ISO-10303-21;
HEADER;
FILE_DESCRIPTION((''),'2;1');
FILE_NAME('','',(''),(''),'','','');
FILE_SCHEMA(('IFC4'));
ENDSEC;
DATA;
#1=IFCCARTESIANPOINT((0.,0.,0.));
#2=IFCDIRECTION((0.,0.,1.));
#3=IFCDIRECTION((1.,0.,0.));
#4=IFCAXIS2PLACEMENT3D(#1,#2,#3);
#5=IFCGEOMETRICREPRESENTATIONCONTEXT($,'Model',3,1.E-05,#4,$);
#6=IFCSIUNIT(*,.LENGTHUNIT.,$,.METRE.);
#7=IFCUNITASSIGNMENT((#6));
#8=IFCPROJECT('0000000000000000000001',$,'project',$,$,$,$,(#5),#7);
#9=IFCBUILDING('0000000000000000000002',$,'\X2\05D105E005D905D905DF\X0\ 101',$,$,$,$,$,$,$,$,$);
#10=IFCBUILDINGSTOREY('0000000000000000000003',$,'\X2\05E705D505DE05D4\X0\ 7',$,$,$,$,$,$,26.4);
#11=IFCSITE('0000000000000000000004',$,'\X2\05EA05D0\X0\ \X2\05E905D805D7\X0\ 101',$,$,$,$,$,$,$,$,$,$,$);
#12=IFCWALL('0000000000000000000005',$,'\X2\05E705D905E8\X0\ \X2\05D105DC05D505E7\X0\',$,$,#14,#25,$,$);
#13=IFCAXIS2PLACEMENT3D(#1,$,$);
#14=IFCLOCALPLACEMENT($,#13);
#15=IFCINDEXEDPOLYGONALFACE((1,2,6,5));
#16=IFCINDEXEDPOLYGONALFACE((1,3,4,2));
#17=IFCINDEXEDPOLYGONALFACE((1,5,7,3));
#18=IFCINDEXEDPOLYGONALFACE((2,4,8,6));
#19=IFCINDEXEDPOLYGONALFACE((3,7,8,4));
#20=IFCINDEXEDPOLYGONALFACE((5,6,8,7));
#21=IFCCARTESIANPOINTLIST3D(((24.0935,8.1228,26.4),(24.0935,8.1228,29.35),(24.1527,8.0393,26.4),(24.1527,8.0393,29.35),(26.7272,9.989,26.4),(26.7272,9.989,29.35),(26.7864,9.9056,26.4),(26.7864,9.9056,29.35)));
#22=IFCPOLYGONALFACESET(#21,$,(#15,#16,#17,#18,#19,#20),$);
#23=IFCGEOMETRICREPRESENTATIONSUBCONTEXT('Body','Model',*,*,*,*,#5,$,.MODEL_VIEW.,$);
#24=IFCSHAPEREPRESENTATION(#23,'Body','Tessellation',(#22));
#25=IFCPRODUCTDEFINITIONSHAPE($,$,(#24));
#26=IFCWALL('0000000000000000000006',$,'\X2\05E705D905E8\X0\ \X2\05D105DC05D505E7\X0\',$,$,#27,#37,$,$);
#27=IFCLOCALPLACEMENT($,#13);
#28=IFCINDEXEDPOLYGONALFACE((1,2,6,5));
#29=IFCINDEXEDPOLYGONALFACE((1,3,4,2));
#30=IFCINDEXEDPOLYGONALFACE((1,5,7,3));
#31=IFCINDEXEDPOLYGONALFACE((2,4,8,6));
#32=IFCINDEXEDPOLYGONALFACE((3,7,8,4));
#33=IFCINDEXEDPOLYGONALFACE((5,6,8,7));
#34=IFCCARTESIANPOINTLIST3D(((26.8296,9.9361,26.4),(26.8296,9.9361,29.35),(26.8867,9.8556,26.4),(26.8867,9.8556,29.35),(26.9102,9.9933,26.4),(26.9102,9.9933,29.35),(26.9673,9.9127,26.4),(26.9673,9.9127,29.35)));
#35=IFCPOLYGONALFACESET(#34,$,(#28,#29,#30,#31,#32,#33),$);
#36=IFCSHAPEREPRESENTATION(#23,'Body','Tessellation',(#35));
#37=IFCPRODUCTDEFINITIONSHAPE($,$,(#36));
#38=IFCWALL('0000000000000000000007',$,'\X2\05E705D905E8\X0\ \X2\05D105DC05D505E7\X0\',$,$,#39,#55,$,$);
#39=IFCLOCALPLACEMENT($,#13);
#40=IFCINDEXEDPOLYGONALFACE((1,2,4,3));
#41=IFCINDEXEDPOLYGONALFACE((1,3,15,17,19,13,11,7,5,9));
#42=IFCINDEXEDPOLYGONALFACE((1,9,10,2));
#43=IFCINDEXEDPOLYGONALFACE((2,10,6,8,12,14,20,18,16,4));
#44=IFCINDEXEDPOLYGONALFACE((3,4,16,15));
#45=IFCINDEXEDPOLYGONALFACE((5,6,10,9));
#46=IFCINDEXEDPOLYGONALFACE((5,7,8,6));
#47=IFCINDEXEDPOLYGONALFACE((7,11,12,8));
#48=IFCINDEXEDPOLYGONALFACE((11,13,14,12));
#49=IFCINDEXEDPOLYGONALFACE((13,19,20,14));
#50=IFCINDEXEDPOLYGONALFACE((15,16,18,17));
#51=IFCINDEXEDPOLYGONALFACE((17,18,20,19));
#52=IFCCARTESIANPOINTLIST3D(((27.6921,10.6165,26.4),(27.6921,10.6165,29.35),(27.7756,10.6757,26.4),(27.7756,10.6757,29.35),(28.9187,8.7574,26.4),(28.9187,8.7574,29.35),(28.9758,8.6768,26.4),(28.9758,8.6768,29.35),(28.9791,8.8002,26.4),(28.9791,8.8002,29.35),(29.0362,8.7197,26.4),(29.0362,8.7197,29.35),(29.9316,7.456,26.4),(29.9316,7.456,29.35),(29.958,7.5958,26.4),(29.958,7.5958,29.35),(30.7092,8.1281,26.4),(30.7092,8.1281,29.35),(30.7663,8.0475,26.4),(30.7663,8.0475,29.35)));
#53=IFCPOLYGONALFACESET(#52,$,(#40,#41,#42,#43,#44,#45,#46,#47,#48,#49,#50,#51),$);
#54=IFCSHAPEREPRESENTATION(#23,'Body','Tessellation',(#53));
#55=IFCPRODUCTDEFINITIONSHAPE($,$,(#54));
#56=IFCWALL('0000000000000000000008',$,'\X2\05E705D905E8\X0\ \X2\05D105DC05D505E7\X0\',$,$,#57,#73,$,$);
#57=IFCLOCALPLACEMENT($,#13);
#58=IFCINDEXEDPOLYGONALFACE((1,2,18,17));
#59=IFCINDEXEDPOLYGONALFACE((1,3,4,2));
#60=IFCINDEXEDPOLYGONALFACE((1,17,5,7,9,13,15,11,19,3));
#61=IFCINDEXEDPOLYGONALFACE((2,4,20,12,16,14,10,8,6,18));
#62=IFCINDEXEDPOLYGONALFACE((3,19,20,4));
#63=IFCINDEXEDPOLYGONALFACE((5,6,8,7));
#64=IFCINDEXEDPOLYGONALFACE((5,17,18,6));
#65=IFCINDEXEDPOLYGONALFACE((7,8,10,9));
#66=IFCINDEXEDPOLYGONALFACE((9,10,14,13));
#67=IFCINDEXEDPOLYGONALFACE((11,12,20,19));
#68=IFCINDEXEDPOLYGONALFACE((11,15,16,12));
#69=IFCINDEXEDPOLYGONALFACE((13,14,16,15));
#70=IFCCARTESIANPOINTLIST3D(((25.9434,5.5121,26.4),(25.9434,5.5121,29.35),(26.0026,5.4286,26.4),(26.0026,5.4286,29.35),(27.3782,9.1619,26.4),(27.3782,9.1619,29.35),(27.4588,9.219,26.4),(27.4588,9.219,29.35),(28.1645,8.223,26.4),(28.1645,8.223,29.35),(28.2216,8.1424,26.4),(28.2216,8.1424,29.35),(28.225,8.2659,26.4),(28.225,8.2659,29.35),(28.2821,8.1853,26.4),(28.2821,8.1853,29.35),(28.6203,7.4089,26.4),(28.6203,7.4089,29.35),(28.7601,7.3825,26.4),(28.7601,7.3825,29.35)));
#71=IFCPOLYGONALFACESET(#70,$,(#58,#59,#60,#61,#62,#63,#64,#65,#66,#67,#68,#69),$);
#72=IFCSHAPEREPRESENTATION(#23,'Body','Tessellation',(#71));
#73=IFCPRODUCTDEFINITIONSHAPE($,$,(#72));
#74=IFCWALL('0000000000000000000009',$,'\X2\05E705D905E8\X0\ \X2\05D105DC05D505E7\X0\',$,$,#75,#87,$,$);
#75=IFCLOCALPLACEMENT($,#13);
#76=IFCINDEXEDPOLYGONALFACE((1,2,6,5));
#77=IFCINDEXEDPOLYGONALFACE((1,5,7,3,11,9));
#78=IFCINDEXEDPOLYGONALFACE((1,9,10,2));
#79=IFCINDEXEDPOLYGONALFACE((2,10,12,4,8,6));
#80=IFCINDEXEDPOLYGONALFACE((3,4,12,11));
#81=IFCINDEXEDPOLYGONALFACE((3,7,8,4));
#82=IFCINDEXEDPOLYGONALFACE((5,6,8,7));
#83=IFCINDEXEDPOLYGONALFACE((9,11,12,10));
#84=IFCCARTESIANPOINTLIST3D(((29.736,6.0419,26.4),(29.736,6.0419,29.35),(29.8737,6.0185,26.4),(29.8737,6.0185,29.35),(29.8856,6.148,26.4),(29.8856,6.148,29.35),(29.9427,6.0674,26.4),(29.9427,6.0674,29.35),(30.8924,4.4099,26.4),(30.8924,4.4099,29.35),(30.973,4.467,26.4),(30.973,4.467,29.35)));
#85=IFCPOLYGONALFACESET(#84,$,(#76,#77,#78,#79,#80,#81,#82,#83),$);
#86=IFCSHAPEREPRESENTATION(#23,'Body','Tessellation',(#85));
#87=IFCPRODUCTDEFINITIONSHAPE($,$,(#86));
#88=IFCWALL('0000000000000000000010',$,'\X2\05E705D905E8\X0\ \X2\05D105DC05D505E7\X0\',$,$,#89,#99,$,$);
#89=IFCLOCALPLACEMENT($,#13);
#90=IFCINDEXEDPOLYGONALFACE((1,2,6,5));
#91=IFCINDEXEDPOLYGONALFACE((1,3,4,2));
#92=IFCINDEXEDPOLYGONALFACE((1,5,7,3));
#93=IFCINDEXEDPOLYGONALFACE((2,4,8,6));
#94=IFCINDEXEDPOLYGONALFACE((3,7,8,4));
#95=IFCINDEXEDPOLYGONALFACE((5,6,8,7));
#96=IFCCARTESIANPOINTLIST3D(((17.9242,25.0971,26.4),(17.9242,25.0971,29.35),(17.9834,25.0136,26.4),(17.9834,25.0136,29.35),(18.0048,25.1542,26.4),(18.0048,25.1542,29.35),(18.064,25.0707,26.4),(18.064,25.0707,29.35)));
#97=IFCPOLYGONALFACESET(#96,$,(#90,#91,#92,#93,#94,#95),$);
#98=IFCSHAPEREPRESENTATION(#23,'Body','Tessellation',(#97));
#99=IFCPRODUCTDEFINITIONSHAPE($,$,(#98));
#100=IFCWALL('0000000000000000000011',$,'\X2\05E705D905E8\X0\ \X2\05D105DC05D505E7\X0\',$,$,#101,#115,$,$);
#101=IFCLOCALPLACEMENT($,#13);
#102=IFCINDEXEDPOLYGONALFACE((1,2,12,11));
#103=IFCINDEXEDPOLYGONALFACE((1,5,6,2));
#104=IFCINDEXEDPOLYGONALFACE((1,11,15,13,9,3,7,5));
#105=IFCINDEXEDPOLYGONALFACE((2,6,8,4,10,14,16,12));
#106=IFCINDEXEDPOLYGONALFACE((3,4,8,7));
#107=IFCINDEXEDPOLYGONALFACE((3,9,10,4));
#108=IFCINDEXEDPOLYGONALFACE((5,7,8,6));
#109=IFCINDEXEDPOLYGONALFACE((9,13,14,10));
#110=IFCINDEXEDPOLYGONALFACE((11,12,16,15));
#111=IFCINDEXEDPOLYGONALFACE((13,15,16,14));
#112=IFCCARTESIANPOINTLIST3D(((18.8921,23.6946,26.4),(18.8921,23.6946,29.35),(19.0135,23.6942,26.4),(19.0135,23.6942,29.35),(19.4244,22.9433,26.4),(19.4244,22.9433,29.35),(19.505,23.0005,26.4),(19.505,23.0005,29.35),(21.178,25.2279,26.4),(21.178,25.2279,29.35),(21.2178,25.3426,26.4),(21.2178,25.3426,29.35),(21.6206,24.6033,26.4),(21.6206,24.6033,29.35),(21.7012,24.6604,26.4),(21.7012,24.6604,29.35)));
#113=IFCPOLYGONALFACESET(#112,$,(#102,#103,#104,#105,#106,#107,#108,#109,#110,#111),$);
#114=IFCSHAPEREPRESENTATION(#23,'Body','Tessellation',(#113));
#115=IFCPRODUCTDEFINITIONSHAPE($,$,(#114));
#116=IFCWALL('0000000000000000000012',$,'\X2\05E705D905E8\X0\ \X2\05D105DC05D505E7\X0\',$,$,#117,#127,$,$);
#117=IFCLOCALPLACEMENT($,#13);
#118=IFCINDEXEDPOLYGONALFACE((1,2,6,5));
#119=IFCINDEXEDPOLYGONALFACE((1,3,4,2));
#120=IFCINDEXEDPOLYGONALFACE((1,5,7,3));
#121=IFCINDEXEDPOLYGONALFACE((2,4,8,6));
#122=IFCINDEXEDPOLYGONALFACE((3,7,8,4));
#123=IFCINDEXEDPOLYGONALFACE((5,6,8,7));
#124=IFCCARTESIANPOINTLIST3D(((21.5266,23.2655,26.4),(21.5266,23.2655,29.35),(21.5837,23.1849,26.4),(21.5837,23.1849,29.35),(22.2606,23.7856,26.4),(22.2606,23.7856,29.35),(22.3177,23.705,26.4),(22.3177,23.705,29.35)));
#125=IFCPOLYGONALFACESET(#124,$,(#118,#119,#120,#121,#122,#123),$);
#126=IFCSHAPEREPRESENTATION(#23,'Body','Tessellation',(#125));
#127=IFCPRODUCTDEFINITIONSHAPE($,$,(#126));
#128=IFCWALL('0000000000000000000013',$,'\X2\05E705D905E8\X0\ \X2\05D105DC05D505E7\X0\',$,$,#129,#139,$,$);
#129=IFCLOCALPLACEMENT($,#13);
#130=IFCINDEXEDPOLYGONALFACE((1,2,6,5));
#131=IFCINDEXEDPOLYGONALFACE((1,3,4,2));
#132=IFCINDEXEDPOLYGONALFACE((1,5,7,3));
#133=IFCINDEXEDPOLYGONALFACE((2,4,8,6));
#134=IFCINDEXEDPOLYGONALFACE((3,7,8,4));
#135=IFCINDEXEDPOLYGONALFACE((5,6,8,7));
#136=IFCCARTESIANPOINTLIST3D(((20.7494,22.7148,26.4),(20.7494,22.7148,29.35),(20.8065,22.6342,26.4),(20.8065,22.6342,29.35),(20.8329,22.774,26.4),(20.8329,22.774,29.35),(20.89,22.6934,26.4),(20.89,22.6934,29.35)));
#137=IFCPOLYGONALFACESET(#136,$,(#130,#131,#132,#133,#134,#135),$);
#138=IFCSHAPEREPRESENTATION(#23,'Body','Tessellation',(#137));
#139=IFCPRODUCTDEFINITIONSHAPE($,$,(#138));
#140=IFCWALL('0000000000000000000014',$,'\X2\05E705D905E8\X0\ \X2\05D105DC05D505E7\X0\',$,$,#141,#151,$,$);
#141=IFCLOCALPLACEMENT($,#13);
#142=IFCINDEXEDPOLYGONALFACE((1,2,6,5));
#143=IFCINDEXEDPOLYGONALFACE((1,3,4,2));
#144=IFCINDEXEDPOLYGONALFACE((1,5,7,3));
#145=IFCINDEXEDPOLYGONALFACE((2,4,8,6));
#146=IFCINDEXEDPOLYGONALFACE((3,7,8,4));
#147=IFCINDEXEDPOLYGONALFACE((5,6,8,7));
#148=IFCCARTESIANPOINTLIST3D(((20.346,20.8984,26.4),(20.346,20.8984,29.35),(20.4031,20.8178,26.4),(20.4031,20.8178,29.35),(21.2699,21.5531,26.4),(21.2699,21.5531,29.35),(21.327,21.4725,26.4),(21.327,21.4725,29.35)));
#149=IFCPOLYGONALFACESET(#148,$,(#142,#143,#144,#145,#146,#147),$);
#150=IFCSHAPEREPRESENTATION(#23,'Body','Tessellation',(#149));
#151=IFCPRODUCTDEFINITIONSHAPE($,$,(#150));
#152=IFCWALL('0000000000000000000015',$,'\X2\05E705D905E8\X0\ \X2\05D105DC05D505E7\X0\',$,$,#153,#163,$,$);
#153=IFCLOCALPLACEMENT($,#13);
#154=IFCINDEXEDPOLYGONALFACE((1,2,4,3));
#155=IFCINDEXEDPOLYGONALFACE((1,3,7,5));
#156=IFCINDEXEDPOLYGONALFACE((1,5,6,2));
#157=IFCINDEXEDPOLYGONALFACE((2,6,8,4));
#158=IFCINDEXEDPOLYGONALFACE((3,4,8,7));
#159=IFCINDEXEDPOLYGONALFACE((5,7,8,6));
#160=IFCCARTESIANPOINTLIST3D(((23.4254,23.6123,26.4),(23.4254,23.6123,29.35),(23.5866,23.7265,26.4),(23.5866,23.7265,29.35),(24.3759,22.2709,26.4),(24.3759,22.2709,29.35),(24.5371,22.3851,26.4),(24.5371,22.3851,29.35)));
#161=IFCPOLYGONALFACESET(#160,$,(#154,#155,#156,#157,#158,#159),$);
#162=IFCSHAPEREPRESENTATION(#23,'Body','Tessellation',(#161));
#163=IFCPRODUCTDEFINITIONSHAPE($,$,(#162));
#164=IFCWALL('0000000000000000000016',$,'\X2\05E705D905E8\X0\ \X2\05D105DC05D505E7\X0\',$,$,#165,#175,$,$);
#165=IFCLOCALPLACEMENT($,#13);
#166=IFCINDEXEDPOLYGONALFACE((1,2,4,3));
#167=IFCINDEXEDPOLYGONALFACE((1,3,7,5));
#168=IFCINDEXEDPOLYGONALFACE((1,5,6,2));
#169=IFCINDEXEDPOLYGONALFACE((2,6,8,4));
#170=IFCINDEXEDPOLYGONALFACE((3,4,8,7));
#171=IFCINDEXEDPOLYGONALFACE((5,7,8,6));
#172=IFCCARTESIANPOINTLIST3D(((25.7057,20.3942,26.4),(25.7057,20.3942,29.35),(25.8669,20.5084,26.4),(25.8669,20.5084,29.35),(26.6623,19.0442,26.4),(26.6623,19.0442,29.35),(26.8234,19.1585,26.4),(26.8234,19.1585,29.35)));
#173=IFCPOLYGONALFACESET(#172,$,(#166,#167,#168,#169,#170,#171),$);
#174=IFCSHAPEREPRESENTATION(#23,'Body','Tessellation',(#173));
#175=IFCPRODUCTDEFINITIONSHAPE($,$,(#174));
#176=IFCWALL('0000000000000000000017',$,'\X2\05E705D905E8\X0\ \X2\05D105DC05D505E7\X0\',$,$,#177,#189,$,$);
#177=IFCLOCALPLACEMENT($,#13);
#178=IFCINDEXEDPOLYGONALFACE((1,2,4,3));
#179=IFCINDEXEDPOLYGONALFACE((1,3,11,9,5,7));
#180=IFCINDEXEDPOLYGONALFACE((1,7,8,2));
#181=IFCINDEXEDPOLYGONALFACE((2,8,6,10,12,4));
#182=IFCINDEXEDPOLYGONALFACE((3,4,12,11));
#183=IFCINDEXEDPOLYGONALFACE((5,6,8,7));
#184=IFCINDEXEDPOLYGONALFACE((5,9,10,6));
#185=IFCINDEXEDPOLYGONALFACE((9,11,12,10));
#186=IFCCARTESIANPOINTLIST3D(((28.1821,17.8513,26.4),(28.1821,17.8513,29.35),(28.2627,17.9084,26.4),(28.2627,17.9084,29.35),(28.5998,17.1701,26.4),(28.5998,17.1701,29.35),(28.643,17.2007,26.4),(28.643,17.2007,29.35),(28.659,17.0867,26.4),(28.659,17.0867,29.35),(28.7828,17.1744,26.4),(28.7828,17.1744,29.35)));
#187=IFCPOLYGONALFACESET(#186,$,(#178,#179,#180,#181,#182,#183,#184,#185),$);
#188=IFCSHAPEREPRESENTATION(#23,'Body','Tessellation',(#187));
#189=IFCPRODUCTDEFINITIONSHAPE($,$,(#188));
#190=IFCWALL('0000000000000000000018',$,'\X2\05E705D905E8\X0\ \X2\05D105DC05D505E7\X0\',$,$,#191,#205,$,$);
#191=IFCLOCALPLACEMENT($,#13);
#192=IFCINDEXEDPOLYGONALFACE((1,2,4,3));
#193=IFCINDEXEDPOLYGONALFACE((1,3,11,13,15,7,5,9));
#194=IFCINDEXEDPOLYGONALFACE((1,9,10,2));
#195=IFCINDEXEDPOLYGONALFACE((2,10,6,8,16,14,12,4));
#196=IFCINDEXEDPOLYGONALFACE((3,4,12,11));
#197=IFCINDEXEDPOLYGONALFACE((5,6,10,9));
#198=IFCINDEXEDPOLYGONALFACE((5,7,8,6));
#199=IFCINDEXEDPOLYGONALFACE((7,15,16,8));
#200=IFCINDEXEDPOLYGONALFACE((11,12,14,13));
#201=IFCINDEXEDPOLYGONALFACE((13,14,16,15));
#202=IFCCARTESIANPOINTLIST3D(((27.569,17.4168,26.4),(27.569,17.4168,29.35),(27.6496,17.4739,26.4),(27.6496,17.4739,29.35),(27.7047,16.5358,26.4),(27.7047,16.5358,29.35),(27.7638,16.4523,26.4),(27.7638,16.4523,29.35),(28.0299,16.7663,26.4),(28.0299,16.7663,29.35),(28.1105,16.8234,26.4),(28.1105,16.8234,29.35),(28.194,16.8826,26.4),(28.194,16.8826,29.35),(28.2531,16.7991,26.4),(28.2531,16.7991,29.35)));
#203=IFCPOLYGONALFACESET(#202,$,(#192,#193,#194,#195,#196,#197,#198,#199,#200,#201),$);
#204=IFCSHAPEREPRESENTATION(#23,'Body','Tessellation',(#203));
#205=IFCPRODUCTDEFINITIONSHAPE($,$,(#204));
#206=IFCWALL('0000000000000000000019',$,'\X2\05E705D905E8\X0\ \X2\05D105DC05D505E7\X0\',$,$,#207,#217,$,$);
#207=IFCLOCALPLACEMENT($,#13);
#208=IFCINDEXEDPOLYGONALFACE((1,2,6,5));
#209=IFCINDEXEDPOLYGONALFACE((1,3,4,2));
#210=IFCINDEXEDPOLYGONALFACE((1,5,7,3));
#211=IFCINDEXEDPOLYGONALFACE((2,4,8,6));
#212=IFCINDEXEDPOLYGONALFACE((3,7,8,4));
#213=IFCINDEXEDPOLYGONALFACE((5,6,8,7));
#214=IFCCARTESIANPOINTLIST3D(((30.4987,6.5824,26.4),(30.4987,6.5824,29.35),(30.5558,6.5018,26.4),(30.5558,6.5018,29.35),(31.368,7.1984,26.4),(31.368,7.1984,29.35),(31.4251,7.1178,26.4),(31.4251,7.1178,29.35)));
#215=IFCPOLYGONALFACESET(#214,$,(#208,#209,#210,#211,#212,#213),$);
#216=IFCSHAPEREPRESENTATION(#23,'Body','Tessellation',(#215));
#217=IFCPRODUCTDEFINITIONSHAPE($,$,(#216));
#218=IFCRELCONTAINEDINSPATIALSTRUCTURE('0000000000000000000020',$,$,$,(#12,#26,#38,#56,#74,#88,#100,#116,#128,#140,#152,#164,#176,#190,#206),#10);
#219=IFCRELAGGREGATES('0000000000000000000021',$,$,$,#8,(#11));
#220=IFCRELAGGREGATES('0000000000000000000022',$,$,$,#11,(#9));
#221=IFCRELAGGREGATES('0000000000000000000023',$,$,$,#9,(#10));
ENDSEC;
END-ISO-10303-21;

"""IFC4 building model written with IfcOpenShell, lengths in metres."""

from ifc_helpers import new_model, si_unit, frame, origin_with_axes, context, subcontext, project, spatial, polyline, outline, extrude, element, save


model = new_model("IFC4")

# Units and contexts
model_context = context("Model", 3, precision=1e-05, world=origin_with_axes())
body_context = subcontext(model_context, "Body", "Model", "MODEL_VIEW")
ifc_project = project(units=[si_unit("LENGTHUNIT", "METRE")], contexts=[model_context])

# Site, building, storey
site = spatial("IfcSite", under=ifc_project, Name="תא שטח 101")
building = spatial("IfcBuilding", under=site, Name="בניין 101")
storey = spatial("IfcBuildingStorey", under=building, Name="קומה 7", Elevation=26.4)

# Walls
element("IfcWall", 1, inside=storey, Name="קיר בלוק", context=body_context, shape_type="SweptSolid", body=[
    extrude(outline(polyline([(26.7864, 9.9056), (26.7272, 9.989), (24.0935, 8.1228), (24.1527, 8.0393), (26.7864, 9.9056)])), frame((0.0, 0.0, 26.4)), (0.0, 0.0, 1.0), 2.95),
])
element("IfcWall", 2, inside=storey, Name="קיר בלוק", context=body_context, shape_type="SweptSolid", body=[
    extrude(outline(polyline([(26.8296, 9.9361), (26.8867, 9.8556), (26.9673, 9.9127), (26.9102, 9.9933), (26.8296, 9.9361)])), frame((0.0, 0.0, 26.4)), (0.0, 0.0, 1.0), 2.95),
])
element("IfcWall", 3, inside=storey, Name="קיר בלוק", context=body_context, shape_type="SweptSolid", body=[
    extrude(outline(polyline([(28.9758, 8.6768), (29.0362, 8.7197), (29.9316, 7.456), (30.7663, 8.0475), (30.7092, 8.1281), (29.958, 7.5958), (27.7756, 10.6757), (27.6921, 10.6165), (28.9791, 8.8002), (28.9187, 8.7574), (28.9758, 8.6768)])), frame((0.0, 0.0, 26.4)), (0.0, 0.0, 1.0), 2.95),
])
element("IfcWall", 4, inside=storey, Name="קיר בלוק", context=body_context, shape_type="SweptSolid", body=[
    extrude(outline(polyline([(26.0026, 5.4286), (28.7601, 7.3825), (28.2216, 8.1424), (28.2821, 8.1853), (28.225, 8.2659), (28.1645, 8.223), (27.4588, 9.219), (27.3782, 9.1619), (28.6203, 7.4089), (25.9434, 5.5121), (26.0026, 5.4286)])), frame((0.0, 0.0, 26.4)), (0.0, 0.0, 1.0), 2.95),
])
element("IfcWall", 5, inside=storey, Name="קיר בלוק", context=body_context, shape_type="SweptSolid", body=[
    extrude(outline(polyline([(29.8737, 6.0185), (29.9427, 6.0674), (29.8856, 6.148), (29.736, 6.0419), (30.8924, 4.4099), (30.973, 4.467), (29.8737, 6.0185)])), frame((0.0, 0.0, 26.4)), (0.0, 0.0, 1.0), 2.95),
])
element("IfcWall", 6, inside=storey, Name="קיר בלוק", context=body_context, shape_type="SweptSolid", body=[
    extrude(outline(polyline([(17.9834, 25.0136), (18.064, 25.0707), (18.0048, 25.1542), (17.9242, 25.0971), (17.9834, 25.0136)])), frame((0.0, 0.0, 26.4)), (0.0, 0.0, 1.0), 2.95),
])
element("IfcWall", 7, inside=storey, Name="קיר בלוק", context=body_context, shape_type="SweptSolid", body=[
    extrude(outline(polyline([(21.2178, 25.3426), (18.8921, 23.6946), (19.4244, 22.9433), (19.505, 23.0005), (19.0135, 23.6942), (21.178, 25.2279), (21.6206, 24.6033), (21.7012, 24.6604), (21.2178, 25.3426)])), frame((0.0, 0.0, 26.4)), (0.0, 0.0, 1.0), 2.95),
])
element("IfcWall", 8, inside=storey, Name="קיר בלוק", context=body_context, shape_type="SweptSolid", body=[
    extrude(outline(polyline([(22.3177, 23.705), (22.2606, 23.7856), (21.5266, 23.2655), (21.5837, 23.1849), (22.3177, 23.705)])), frame((0.0, 0.0, 26.4)), (0.0, 0.0, 1.0), 2.95),
])
element("IfcWall", 9, inside=storey, Name="קיר בלוק", context=body_context, shape_type="SweptSolid", body=[
    extrude(outline(polyline([(20.8065, 22.6342), (20.89, 22.6934), (20.8329, 22.774), (20.7494, 22.7148), (20.8065, 22.6342)])), frame((0.0, 0.0, 26.4)), (0.0, 0.0, 1.0), 2.95),
])
element("IfcWall", 10, inside=storey, Name="קיר בלוק", context=body_context, shape_type="SweptSolid", body=[
    extrude(outline(polyline([(21.2699, 21.5531), (20.346, 20.8984), (20.4031, 20.8178), (21.327, 21.4725), (21.2699, 21.5531)])), frame((0.0, 0.0, 26.4)), (0.0, 0.0, 1.0), 2.95),
])
element("IfcWall", 11, inside=storey, Name="קיר בלוק", context=body_context, shape_type="SweptSolid", body=[
    extrude(outline(polyline([(24.3759, 22.2709), (24.5371, 22.3851), (23.5866, 23.7265), (23.4254, 23.6123), (24.3759, 22.2709)])), frame((0.0, 0.0, 26.4)), (0.0, 0.0, 1.0), 2.95),
])
element("IfcWall", 12, inside=storey, Name="קיר בלוק", context=body_context, shape_type="SweptSolid", body=[
    extrude(outline(polyline([(26.6623, 19.0442), (26.8234, 19.1585), (25.8669, 20.5084), (25.7057, 20.3942), (26.6623, 19.0442)])), frame((0.0, 0.0, 26.4)), (0.0, 0.0, 1.0), 2.95),
])
element("IfcWall", 13, inside=storey, Name="קיר בלוק", context=body_context, shape_type="SweptSolid", body=[
    extrude(outline(polyline([(28.5998, 17.1701), (28.659, 17.0867), (28.7828, 17.1744), (28.2627, 17.9084), (28.1821, 17.8513), (28.643, 17.2007), (28.5998, 17.1701)])), frame((0.0, 0.0, 26.4)), (0.0, 0.0, 1.0), 2.95),
])
element("IfcWall", 14, inside=storey, Name="קיר בלוק", context=body_context, shape_type="SweptSolid", body=[
    extrude(outline(polyline([(27.7638, 16.4523), (28.2531, 16.7991), (28.194, 16.8826), (28.1105, 16.8234), (27.6496, 17.4739), (27.569, 17.4168), (28.0299, 16.7663), (27.7047, 16.5358), (27.7638, 16.4523)])), frame((0.0, 0.0, 26.4)), (0.0, 0.0, 1.0), 2.95),
])
element("IfcWall", 15, inside=storey, Name="קיר בלוק", context=body_context, shape_type="SweptSolid", body=[
    extrude(outline(polyline([(31.368, 7.1984), (30.4987, 6.5824), (30.5558, 6.5018), (31.4251, 7.1178), (31.368, 7.1984)])), frame((0.0, 0.0, 26.4)), (0.0, 0.0, 1.0), 2.95),
])

save(model, "model.ifc")
